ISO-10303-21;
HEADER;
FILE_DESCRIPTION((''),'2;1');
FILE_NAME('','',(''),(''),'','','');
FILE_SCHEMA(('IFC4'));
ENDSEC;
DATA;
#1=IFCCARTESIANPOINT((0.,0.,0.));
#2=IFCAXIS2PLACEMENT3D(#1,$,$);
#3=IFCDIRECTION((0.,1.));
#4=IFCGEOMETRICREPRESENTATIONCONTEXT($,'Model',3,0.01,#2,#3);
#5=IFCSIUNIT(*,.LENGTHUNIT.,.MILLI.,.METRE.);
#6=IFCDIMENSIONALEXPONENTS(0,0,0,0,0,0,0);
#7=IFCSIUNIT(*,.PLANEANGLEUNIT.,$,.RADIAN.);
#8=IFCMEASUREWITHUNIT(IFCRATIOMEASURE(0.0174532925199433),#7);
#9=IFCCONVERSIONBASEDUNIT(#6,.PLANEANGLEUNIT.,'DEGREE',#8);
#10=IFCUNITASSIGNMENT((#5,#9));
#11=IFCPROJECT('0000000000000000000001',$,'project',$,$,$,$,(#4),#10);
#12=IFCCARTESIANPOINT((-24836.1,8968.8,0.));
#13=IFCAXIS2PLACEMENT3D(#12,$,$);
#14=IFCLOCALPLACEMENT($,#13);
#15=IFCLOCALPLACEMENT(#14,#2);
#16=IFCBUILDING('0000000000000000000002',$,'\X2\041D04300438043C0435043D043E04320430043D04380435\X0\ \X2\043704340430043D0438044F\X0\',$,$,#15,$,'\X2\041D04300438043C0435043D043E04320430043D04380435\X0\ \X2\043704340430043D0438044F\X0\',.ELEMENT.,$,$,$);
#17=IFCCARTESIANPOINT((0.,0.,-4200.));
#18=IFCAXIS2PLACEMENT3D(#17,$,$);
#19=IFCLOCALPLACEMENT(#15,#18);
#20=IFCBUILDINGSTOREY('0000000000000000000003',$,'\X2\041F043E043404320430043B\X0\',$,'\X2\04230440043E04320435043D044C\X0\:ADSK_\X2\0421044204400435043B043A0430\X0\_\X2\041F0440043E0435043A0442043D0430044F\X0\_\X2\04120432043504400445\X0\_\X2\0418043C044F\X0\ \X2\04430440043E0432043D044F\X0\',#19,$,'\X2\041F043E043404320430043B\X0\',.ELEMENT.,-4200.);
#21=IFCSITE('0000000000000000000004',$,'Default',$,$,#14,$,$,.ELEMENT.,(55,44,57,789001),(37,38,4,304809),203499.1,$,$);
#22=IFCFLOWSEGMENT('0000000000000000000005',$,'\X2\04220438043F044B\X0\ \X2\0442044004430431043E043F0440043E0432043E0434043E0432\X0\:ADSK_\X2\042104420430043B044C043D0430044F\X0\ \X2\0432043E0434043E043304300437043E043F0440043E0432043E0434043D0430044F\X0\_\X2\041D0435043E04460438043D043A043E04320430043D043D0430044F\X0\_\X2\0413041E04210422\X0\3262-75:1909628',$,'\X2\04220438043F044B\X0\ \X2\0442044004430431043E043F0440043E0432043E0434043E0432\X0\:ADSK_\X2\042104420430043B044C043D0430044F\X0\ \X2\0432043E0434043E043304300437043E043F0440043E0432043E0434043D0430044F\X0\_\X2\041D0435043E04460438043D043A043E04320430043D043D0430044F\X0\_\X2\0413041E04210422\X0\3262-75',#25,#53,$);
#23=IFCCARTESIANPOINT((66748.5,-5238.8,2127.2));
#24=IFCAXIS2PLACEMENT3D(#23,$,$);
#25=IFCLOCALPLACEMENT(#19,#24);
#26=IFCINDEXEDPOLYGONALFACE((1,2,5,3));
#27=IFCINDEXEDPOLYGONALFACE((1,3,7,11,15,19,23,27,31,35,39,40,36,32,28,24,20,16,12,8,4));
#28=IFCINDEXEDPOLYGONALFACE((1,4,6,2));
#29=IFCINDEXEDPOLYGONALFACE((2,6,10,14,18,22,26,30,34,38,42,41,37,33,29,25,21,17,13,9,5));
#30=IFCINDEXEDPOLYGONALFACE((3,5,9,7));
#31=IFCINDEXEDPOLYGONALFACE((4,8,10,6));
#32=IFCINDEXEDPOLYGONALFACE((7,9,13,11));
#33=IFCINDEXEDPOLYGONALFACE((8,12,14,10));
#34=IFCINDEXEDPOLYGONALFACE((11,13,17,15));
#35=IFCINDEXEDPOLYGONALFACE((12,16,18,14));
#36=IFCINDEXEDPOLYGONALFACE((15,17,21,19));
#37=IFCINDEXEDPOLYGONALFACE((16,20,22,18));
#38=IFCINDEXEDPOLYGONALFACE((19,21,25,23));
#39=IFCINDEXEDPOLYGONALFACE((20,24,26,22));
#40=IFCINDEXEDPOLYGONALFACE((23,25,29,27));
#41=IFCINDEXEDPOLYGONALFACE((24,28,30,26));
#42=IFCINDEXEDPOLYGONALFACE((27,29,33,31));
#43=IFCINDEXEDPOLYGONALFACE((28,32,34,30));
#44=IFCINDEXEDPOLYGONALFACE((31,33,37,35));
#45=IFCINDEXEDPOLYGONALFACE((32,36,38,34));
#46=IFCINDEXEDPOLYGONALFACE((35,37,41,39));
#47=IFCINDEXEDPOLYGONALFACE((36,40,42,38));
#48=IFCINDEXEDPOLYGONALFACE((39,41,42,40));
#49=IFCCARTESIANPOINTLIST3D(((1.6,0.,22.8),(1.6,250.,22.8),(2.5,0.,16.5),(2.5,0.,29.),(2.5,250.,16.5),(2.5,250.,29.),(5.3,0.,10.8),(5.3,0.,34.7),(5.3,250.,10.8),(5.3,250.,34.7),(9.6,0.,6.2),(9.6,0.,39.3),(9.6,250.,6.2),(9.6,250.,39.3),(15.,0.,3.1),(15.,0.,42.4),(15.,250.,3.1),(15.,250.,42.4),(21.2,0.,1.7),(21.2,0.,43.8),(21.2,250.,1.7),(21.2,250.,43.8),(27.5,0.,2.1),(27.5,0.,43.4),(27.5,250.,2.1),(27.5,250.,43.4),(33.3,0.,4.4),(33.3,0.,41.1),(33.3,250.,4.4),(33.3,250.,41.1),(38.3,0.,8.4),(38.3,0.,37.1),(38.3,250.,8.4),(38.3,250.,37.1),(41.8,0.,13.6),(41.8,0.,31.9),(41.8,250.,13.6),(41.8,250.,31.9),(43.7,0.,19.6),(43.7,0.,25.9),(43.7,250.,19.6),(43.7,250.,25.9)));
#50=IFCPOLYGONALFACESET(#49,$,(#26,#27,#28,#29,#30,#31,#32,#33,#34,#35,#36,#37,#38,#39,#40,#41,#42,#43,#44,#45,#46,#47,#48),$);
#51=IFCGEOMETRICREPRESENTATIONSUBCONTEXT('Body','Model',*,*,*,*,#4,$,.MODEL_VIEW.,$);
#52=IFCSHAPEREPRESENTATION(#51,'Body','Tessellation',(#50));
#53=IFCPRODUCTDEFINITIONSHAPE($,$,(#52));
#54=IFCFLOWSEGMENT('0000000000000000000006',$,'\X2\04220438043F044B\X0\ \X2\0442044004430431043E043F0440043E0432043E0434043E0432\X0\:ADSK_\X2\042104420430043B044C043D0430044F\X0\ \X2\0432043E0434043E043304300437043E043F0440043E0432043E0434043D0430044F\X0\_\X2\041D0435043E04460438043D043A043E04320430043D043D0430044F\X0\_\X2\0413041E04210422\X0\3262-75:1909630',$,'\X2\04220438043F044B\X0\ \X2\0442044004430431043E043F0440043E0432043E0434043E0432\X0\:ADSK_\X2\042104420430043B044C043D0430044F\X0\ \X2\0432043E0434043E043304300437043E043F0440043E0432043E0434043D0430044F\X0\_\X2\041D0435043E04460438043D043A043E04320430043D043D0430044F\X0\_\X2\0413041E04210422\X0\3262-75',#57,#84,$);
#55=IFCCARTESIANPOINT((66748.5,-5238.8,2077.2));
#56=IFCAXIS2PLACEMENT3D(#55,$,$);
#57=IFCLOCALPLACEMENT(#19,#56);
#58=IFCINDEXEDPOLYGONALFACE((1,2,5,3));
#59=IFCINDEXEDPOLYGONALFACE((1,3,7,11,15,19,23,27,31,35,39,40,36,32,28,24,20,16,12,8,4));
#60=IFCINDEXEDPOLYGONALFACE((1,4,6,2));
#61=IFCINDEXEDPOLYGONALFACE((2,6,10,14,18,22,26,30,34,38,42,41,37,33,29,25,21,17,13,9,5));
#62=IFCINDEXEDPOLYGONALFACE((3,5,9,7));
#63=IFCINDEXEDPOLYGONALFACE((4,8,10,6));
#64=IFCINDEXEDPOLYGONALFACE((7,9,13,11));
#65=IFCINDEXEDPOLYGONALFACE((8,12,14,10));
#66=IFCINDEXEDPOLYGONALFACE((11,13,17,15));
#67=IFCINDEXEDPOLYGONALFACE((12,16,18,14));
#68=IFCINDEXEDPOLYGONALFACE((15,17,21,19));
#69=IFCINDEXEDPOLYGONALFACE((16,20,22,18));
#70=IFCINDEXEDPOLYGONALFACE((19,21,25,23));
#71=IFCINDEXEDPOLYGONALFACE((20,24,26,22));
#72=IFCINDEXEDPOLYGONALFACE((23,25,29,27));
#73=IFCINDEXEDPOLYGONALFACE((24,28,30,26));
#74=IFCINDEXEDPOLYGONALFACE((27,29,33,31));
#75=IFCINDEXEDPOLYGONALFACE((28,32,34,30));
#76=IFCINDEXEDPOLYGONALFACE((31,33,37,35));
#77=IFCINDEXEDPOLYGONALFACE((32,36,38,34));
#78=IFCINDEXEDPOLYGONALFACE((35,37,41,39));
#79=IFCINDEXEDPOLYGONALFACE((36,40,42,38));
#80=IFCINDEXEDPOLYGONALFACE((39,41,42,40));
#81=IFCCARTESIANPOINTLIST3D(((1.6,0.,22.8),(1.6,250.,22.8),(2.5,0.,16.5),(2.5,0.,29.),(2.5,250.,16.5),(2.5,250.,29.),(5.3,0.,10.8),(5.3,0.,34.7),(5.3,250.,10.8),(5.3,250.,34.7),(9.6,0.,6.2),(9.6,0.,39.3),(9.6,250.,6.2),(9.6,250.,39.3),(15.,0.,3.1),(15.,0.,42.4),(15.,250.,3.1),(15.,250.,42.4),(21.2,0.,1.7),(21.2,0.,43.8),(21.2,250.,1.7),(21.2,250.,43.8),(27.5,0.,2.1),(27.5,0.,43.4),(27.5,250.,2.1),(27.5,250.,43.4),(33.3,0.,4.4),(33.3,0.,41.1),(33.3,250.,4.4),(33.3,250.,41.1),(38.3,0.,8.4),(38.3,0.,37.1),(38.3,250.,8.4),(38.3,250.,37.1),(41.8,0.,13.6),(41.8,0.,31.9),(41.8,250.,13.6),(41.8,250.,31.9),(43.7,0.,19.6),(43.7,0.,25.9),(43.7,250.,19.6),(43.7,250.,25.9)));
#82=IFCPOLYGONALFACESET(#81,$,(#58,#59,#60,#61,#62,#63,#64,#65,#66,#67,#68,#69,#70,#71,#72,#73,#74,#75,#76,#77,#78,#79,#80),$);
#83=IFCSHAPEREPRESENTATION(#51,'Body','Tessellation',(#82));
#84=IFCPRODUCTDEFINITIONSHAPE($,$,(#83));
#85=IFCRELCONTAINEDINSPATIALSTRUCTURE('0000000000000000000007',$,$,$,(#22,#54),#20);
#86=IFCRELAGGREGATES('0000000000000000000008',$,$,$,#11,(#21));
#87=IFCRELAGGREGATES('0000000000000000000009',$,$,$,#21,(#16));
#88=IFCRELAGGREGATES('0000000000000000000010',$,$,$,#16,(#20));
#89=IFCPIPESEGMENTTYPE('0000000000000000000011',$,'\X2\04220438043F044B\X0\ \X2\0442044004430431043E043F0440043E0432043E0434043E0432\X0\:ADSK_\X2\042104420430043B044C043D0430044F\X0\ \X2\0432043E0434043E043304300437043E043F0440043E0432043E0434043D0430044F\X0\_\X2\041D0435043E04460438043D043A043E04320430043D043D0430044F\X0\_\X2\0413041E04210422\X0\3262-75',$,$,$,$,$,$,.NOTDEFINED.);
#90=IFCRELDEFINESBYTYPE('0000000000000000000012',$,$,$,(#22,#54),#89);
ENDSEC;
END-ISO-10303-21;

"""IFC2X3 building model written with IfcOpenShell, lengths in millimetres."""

from ifc_helpers import new_model, entity, si_unit, converted_unit, direction, frame, origin, origin_2d_with_axis, place, context, subcontext, project, spatial, circle, extrude, type_object, element, save


model = new_model("IFC2X3")

# Units and contexts
model_context = context("Model", 3, precision=0.01, world=origin(), true_north=direction((0.0, 1.0)))
body_context = subcontext(model_context, "Body", "Model", "MODEL_VIEW")
ifc_project = project(units=[si_unit("LENGTHUNIT", "METRE", prefix="MILLI"), converted_unit("PLANEANGLEUNIT", "DEGREE", entity("IfcRatioMeasure", 0.0174532925199433), si_unit("PLANEANGLEUNIT", "RADIAN"), dimensions=[0, 0, 0, 0, 0, 0, 0])], contexts=[model_context])

# Site, building, storey
site_placement = place(None, frame((-24836.1, 8968.8, 0.0)))
site = spatial("IfcSite", under=ifc_project, at=site_placement, Name="Default", CompositionType="ELEMENT", RefLatitude=(55, 44, 57, 789001), RefLongitude=(37, 38, 4, 304809), RefElevation=203499.1)
building_placement = place(site_placement, origin())
building = spatial("IfcBuilding", under=site, at=building_placement, Name="Наименование здания", LongName="Наименование здания", CompositionType="ELEMENT")
storey_placement = place(building_placement, frame((0.0, 0.0, -4200.0)))
storey = spatial("IfcBuildingStorey", under=building, at=storey_placement, Name="Подвал", ObjectType="Уровень:ADSK_Стрелка_Проектная_Вверх_Имя уровня", LongName="Подвал", CompositionType="ELEMENT", Elevation=-4200.0)

# Flow segments
pipe_segment_type_1 = type_object("IfcPipeSegmentType", Name="Типы трубопроводов:ADSK_Стальная водогазопроводная_Неоцинкованная_ГОСТ3262-75", PredefinedType="NOTDEFINED")
for number, where, name in (
    (1, (66748.5, -5238.8, 2127.2), "Типы трубопроводов:ADSK_Стальная водогазопроводная_Неоцинкованная_ГОСТ3262-75:1909628"),
    (2, (66748.5, -5238.8, 2077.2), "Типы трубопроводов:ADSK_Стальная водогазопроводная_Неоцинкованная_ГОСТ3262-75:1909630"),
):
    element("IfcFlowSegment", number, at=place(storey_placement, frame(where)), inside=storey, type_object=pipe_segment_type_1, Name=name, ObjectType="Типы трубопроводов:ADSK_Стальная водогазопроводная_Неоцинкованная_ГОСТ3262-75", context=body_context, shape_type="SweptSolid", body=[
        extrude(circle(Radius=21.1, at=origin_2d_with_axis()), frame((22.8, 0.0, 22.8), z_axis=(0.0, 1.0, 0.0), x_axis=(-1.0, 0.0, 0.0)), (0.0, 0.0, 1.0), 250.0),
    ])

save(model, "model.ifc")
